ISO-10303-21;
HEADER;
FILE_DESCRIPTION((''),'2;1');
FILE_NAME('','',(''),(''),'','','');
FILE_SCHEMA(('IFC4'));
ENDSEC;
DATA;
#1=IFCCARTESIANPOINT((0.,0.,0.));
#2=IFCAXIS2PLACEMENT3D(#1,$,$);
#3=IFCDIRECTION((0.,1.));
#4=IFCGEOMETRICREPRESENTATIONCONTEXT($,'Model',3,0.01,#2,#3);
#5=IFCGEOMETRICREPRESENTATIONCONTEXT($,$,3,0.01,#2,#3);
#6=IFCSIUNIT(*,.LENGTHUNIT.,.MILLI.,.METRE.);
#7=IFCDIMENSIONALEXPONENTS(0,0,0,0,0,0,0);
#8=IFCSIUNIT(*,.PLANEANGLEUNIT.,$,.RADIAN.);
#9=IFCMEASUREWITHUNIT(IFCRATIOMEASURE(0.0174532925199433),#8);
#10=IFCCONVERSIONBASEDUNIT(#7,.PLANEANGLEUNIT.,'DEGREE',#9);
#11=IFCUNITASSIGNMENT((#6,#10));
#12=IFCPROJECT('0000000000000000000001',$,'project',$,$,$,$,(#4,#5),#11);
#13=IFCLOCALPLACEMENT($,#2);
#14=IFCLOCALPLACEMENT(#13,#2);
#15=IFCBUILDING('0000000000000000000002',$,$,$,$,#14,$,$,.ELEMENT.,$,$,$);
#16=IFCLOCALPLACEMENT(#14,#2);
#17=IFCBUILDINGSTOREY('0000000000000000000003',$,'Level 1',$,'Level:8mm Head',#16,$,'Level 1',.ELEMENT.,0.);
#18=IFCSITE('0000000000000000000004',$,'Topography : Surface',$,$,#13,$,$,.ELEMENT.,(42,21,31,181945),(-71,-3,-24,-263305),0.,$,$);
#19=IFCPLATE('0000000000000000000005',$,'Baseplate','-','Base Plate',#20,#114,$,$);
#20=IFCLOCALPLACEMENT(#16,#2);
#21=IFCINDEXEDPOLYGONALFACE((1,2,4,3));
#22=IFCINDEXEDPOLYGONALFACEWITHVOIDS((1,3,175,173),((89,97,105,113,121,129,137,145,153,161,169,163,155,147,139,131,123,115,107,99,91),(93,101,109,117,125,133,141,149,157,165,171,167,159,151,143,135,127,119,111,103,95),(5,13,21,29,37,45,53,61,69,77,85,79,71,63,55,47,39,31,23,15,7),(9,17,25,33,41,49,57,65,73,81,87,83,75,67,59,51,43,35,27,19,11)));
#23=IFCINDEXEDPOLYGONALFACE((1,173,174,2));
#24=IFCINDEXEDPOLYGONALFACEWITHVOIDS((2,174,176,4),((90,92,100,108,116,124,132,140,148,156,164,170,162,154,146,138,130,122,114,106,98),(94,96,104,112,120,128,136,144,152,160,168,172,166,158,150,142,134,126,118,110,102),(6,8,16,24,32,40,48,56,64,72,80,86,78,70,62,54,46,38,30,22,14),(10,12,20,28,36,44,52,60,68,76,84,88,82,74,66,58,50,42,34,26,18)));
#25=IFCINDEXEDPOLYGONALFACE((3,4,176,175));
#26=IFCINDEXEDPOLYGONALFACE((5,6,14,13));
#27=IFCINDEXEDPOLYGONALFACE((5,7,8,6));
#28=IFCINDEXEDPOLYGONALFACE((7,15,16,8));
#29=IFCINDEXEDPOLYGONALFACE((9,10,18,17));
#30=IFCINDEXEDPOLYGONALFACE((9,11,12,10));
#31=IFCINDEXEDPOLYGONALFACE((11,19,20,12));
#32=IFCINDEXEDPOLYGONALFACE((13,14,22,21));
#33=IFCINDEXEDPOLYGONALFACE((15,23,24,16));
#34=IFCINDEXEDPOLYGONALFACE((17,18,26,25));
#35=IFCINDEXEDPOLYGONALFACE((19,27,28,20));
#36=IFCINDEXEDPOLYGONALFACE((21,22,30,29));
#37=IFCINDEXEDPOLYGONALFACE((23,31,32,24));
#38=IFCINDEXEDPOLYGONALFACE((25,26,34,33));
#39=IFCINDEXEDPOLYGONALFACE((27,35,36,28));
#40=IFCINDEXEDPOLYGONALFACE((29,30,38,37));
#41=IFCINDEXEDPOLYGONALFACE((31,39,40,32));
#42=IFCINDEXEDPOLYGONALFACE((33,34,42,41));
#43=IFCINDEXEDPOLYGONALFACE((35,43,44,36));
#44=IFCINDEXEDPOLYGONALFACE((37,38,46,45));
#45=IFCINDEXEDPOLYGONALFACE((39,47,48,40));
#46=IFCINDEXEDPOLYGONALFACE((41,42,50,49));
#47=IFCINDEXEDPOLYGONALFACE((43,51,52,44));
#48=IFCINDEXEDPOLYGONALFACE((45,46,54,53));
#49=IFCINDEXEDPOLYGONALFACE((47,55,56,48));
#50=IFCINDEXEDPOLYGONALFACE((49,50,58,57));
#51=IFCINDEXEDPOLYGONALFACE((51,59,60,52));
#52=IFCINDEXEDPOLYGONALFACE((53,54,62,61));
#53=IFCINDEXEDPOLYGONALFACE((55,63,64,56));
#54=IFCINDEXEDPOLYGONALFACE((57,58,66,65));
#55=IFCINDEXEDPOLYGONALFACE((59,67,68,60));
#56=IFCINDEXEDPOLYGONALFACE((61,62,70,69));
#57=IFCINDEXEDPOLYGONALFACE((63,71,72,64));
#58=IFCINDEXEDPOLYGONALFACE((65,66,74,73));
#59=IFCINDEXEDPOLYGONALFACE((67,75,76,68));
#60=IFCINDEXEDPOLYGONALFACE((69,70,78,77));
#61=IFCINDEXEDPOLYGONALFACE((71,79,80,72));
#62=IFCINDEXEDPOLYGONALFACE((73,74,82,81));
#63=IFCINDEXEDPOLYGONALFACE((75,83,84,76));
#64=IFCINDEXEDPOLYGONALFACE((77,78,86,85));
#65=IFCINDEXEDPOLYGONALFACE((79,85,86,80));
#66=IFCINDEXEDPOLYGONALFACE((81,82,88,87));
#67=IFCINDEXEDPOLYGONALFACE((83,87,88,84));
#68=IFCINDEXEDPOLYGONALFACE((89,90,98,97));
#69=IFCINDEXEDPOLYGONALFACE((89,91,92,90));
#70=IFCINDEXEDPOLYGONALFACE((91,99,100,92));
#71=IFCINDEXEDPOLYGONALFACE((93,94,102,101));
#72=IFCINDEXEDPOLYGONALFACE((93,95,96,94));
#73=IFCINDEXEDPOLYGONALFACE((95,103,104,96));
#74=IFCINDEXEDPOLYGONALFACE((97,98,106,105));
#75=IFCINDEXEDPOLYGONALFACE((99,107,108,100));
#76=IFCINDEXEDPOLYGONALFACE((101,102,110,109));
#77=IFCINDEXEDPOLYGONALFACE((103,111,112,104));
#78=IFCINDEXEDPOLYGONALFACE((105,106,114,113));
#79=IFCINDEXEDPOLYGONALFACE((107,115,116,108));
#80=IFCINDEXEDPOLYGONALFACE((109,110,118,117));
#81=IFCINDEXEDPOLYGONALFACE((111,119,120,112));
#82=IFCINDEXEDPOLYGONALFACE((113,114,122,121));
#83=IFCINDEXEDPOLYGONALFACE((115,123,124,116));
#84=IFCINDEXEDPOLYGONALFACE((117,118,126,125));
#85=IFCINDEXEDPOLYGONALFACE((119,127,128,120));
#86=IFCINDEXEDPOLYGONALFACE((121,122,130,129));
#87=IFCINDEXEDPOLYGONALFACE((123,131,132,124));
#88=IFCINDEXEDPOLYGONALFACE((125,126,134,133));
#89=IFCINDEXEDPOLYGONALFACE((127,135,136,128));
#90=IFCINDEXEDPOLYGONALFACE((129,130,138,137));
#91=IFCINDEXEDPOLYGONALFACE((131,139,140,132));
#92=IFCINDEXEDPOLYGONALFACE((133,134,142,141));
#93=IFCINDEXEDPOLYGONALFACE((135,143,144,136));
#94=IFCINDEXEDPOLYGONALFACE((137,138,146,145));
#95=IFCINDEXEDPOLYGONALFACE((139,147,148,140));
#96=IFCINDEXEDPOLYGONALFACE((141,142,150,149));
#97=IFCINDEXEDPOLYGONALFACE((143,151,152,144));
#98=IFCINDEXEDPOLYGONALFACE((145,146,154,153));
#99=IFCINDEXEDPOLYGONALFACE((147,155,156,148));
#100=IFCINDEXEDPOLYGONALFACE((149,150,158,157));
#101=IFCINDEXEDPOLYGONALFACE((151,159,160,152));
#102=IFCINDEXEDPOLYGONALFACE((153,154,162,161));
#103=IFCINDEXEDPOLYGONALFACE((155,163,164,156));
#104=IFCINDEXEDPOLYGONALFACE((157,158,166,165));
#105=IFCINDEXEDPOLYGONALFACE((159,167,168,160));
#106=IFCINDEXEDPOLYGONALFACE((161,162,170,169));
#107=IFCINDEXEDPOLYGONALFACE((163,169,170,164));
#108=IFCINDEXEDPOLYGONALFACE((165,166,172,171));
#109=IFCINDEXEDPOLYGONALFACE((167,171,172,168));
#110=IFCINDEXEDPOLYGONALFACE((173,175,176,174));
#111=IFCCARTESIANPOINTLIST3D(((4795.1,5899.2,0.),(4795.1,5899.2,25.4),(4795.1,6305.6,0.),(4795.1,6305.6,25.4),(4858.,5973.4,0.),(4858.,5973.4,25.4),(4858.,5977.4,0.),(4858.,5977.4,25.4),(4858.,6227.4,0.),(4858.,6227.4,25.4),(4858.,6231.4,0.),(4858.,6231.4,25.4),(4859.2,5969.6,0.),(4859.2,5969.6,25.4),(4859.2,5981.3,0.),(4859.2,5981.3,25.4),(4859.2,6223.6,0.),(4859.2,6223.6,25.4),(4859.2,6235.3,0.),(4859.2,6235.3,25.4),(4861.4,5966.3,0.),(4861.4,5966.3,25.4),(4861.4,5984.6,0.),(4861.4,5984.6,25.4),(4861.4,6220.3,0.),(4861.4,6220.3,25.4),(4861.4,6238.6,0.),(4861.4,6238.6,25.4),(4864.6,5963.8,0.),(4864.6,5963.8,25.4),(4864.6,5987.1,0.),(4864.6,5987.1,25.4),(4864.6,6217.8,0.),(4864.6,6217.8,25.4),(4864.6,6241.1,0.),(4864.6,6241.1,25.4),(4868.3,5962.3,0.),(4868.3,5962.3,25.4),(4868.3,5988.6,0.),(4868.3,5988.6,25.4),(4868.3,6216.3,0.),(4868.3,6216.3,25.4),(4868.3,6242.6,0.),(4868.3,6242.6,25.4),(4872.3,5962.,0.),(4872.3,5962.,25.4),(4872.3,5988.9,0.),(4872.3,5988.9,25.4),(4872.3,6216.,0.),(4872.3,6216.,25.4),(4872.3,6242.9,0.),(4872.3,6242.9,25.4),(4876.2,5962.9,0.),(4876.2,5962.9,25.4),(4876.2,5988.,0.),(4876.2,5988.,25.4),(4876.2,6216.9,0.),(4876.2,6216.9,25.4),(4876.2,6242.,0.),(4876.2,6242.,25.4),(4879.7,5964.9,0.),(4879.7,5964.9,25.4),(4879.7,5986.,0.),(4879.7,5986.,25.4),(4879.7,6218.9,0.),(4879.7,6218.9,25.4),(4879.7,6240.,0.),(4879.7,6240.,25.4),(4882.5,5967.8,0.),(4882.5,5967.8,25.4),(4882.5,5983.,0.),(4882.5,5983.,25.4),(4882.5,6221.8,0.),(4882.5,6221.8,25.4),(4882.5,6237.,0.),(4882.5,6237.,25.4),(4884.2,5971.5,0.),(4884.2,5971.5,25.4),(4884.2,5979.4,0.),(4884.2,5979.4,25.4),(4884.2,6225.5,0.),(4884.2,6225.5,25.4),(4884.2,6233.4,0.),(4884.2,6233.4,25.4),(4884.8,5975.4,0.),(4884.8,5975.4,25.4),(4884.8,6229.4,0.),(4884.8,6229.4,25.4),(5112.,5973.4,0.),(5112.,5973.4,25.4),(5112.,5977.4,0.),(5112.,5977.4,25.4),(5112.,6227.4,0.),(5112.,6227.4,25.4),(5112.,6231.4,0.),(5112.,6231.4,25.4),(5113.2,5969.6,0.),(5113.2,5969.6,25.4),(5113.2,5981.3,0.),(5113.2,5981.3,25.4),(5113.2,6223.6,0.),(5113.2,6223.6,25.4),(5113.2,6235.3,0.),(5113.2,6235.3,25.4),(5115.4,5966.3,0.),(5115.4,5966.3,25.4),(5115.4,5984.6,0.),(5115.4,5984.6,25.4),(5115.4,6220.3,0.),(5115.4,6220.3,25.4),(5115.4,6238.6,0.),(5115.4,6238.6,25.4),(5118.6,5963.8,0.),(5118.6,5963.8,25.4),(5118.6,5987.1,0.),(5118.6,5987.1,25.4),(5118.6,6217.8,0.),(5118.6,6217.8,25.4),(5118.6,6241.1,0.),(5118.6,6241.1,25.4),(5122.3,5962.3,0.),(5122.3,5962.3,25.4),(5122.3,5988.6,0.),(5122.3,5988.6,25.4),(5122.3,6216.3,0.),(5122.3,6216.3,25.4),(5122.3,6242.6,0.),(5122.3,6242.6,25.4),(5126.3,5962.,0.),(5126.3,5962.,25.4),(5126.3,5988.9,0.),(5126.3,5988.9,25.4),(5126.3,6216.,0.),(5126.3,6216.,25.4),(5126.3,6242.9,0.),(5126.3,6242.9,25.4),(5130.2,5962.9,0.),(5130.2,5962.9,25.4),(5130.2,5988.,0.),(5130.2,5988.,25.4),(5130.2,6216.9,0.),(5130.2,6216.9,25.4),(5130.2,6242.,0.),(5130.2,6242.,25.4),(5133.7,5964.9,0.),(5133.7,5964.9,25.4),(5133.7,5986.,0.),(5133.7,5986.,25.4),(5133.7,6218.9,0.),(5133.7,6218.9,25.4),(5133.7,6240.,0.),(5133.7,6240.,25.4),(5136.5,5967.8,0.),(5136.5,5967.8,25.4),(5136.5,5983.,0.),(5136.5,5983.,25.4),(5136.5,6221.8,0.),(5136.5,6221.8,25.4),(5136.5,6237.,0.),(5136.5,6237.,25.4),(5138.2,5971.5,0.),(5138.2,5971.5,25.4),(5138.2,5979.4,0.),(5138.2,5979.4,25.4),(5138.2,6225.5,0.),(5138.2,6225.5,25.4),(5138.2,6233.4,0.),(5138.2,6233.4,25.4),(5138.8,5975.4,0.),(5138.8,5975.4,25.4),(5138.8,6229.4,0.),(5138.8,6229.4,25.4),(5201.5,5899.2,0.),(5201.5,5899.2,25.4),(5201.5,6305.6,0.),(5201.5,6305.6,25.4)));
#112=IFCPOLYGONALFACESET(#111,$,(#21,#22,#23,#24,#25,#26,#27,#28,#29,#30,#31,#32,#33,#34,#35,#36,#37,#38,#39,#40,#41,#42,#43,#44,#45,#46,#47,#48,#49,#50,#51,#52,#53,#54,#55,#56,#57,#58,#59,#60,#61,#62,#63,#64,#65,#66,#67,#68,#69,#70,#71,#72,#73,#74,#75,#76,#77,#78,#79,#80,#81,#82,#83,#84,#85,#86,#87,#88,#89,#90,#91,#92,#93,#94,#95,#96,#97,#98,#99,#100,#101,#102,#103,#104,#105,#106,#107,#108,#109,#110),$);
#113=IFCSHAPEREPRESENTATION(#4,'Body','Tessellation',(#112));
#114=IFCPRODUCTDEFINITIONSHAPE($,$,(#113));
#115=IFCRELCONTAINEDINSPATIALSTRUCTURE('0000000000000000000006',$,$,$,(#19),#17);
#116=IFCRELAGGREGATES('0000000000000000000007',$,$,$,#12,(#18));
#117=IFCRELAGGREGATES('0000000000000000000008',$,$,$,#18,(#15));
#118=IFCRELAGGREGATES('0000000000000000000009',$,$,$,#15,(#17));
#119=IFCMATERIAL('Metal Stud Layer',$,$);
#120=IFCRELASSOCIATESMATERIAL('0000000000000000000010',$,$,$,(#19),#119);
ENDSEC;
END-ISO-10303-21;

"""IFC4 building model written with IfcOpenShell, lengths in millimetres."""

from ifc_helpers import new_model, entity, si_unit, converted_unit, direction, frame, frame_2d, origin, origin_with_axes, place, context, project, spatial, polyline, circle, outline, extrude, material, element, save


model = new_model("IFC4")

# Units and contexts
model_context = context("Model", 3, precision=0.01, world=origin(), true_north=direction((0.0, 1.0)))
context_of_model = context(None, 3, precision=0.01, world=origin(), true_north=direction((0.0, 1.0)))
ifc_project = project(units=[si_unit("LENGTHUNIT", "METRE", prefix="MILLI"), converted_unit("PLANEANGLEUNIT", "DEGREE", entity("IfcRatioMeasure", 0.0174532925199433), si_unit("PLANEANGLEUNIT", "RADIAN"), dimensions=[0, 0, 0, 0, 0, 0, 0])], contexts=[model_context, context_of_model])

# Site, building, storey
site_placement = place(None, origin())
site = spatial("IfcSite", under=ifc_project, at=site_placement, Name="Topography : Surface", CompositionType="ELEMENT", RefLatitude=(42, 21, 31, 181945), RefLongitude=(-71, -3, -24, -263305), RefElevation=0.0)
building_placement = place(site_placement, origin())
building = spatial("IfcBuilding", under=site, at=building_placement, CompositionType="ELEMENT")
storey_placement = place(building_placement, origin())
storey = spatial("IfcBuildingStorey", under=building, at=storey_placement, Name="Level 1", ObjectType="Level:8mm Head", LongName="Level 1", CompositionType="ELEMENT", Elevation=0.0)

# Plate, openings
ifc_material_1 = material(Name="Metal Stud Layer")
plate_1_placement = place(storey_placement, frame((4795.1, 6305.6, 25.4), z_axis=(0.0, 0.0, -1.0), x_axis=(1.0, 0.0, 0.0)))
plate_1 = element("IfcPlate", 1, at=plate_1_placement, inside=storey, material=ifc_material_1, Name="Baseplate", Description="-", ObjectType="Base Plate", context=model_context, shape_type="SweptSolid", body=[
    extrude(outline(polyline([(0.0, 0.0), (406.4, 0.0), (406.4, 406.4), (0.0, 406.4), (0.0, 0.0)])), origin_with_axes(), (0.0, 0.0, 1.0), 25.4),
])
opening_1_placement = place(plate_1_placement, frame((203.2, 203.2, 25.9), z_axis=(0.0, 0.0, -1.0), x_axis=(1.0, 0.0, 0.0)))
element("IfcOpeningElement", 2, at=opening_1_placement, cuts=plate_1, ObjectType="Opening", context=model_context, shape_type="SweptSolid", body=[
    extrude(circle(Radius=13.5, at=frame_2d((127.0, 127.0), x_axis=(1.0, 0.0))), origin(), (0.0, 0.0, 1.0), 26.4),
])
opening_2_placement = place(plate_1_placement, frame((203.2, 203.2, 25.9), z_axis=(0.0, 0.0, -1.0), x_axis=(1.0, 0.0, 0.0)))
element("IfcOpeningElement", 3, at=opening_2_placement, cuts=plate_1, ObjectType="Opening", context=model_context, shape_type="SweptSolid", body=[
    extrude(circle(Radius=13.5, at=frame_2d((-127.0, 127.0), x_axis=(1.0, 0.0))), origin(), (0.0, 0.0, 1.0), 26.4),
])
opening_3_placement = place(plate_1_placement, frame((203.2, 203.2, 25.9), z_axis=(0.0, 0.0, -1.0), x_axis=(1.0, 0.0, 0.0)))
element("IfcOpeningElement", 4, at=opening_3_placement, cuts=plate_1, ObjectType="Opening", context=model_context, shape_type="SweptSolid", body=[
    extrude(circle(Radius=13.5, at=frame_2d((127.0, -127.0), x_axis=(1.0, 0.0))), origin(), (0.0, 0.0, 1.0), 26.4),
])
opening_4_placement = place(plate_1_placement, frame((203.2, 203.2, 25.9), z_axis=(0.0, 0.0, -1.0), x_axis=(1.0, 0.0, 0.0)))
element("IfcOpeningElement", 5, at=opening_4_placement, cuts=plate_1, ObjectType="Opening", context=model_context, shape_type="SweptSolid", body=[
    extrude(circle(Radius=13.5, at=frame_2d((-127.0, -127.0), x_axis=(1.0, 0.0))), origin(), (0.0, 0.0, 1.0), 26.4),
])

save(model, "model.ifc")
